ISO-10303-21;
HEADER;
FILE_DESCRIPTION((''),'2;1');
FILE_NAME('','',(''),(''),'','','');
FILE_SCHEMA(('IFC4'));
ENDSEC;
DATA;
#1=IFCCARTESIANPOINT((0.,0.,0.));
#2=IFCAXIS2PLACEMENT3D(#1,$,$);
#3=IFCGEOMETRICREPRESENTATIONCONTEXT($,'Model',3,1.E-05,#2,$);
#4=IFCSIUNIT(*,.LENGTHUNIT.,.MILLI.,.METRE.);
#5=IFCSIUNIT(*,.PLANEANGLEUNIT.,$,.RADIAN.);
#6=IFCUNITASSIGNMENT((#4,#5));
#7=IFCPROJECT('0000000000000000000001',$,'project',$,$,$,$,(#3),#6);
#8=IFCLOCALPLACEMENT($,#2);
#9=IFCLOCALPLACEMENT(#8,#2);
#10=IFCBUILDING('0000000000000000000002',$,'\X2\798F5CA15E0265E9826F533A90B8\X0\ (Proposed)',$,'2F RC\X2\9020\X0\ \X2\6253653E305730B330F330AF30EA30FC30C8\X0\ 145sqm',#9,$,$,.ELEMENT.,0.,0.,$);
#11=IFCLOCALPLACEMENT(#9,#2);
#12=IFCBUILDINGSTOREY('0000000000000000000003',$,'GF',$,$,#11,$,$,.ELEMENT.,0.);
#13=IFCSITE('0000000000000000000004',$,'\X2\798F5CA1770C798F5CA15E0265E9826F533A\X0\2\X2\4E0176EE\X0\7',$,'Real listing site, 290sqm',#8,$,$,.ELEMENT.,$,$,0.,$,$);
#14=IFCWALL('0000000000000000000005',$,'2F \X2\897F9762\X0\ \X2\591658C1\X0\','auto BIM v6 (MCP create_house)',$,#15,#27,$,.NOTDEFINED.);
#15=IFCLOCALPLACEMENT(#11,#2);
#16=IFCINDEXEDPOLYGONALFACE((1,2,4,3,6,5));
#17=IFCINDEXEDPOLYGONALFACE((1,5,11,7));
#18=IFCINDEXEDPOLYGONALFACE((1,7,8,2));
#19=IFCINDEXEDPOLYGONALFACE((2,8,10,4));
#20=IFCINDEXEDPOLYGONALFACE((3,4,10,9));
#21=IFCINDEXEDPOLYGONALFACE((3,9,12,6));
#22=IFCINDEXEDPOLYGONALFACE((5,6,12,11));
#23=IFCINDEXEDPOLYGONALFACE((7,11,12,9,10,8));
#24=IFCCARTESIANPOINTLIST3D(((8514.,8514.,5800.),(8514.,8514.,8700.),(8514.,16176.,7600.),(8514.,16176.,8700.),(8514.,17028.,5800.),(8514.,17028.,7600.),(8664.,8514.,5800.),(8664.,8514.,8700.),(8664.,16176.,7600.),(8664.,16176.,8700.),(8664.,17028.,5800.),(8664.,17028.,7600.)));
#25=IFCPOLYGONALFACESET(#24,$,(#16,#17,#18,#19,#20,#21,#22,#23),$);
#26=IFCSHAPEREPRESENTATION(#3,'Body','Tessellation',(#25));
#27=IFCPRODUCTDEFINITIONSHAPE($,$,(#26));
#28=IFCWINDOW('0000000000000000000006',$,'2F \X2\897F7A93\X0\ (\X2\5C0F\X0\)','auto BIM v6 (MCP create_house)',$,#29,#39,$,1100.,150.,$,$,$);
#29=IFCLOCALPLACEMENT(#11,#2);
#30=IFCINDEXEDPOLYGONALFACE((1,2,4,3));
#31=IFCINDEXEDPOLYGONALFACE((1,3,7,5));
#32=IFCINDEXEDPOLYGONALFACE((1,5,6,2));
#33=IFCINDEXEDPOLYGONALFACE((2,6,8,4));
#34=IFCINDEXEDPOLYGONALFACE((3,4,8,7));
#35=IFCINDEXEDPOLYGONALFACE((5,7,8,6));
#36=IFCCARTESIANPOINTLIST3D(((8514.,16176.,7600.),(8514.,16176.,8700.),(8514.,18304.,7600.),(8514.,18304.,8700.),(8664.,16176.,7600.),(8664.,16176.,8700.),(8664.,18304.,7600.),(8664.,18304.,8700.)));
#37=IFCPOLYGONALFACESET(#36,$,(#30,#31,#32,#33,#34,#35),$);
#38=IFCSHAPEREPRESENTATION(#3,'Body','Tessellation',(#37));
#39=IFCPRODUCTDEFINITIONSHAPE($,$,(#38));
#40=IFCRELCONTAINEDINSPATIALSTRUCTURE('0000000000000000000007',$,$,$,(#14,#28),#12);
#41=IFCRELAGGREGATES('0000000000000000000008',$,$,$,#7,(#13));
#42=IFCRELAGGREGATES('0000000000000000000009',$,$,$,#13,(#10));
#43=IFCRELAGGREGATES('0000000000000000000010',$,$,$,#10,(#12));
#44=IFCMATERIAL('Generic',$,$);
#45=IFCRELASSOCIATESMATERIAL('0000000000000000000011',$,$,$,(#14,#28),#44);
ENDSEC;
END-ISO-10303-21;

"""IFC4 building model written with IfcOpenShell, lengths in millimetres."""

from ifc_helpers import new_model, si_unit, frame, frame_2d, origin, place, context, project, spatial, rectangle, extrude, material, element, fill, save


model = new_model("IFC4")

# Units and contexts
model_context = context("Model", 3, precision=1e-05, world=origin())
ifc_project = project(units=[si_unit("LENGTHUNIT", "METRE", prefix="MILLI"), si_unit("PLANEANGLEUNIT", "RADIAN")], contexts=[model_context])

# Site, building, storey
site_placement = place(None, origin())
site = spatial("IfcSite", under=ifc_project, at=site_placement, Name="福岡県福岡市早良区2丁目7", ObjectType="Real listing site, 290sqm", CompositionType="ELEMENT", RefElevation=0.0)
building_placement = place(site_placement, origin())
building = spatial("IfcBuilding", under=site, at=building_placement, Name="福岡市早良区邸 (Proposed)", ObjectType="2F RC造 打放しコンクリート 145sqm", CompositionType="ELEMENT", ElevationOfRefHeight=0.0, ElevationOfTerrain=0.0)
storey_placement = place(building_placement, origin())
storey = spatial("IfcBuildingStorey", under=building, at=storey_placement, Name="GF", CompositionType="ELEMENT", Elevation=0.0)

# Shared definitions
ifc_material = material(Name="Generic")

# Wall, opening, window
wall_1_placement = place(storey_placement, frame((4257.0, 4257.0, 2900.0)))
wall_1 = element("IfcWall", 1, at=wall_1_placement, inside=storey, material=ifc_material, Name="2F 西面 外壁", Description="auto BIM v6 (MCP create_house)", PredefinedType="NOTDEFINED", context=model_context, shape_type="SweptSolid", body=[
    extrude(rectangle(XDim=150.0, YDim=8514.0, at=frame_2d((75.0, 4257.0))), frame((4257.0, 4257.0, 2900.0)), (0.0, 0.0, 1.0), 2900.0),
])
opening_1_placement = place(storey_placement, frame((4257.0, 8088.0, 3800.0)))
opening_1 = element("IfcOpeningElement", 2, at=opening_1_placement, cuts=wall_1, PredefinedType="NOTDEFINED", context=model_context, shape_type="SweptSolid", body=[
    extrude(rectangle(XDim=150.0, YDim=2128.0, at=frame_2d((75.0, 1064.0))), frame((4257.0, 8088.0, 3800.0)), (0.0, 0.0, 1.0), 1100.0),
])
window_1_placement = place(storey_placement, frame((4257.0, 8088.0, 3800.0)))
window_1 = element("IfcWindow", 3, at=window_1_placement, inside=storey, material=ifc_material, Name="2F 西窓 (小)", Description="auto BIM v6 (MCP create_house)", OverallHeight=1100.0, OverallWidth=150.0, context=model_context, shape_type="SweptSolid", body=[
    extrude(rectangle(XDim=150.0, YDim=2128.0, at=frame_2d((75.0, 1064.0))), frame((4257.0, 8088.0, 3800.0)), (0.0, 0.0, 1.0), 1100.0),
])
fill(opening_1, window_1)

save(model, "model.ifc")
